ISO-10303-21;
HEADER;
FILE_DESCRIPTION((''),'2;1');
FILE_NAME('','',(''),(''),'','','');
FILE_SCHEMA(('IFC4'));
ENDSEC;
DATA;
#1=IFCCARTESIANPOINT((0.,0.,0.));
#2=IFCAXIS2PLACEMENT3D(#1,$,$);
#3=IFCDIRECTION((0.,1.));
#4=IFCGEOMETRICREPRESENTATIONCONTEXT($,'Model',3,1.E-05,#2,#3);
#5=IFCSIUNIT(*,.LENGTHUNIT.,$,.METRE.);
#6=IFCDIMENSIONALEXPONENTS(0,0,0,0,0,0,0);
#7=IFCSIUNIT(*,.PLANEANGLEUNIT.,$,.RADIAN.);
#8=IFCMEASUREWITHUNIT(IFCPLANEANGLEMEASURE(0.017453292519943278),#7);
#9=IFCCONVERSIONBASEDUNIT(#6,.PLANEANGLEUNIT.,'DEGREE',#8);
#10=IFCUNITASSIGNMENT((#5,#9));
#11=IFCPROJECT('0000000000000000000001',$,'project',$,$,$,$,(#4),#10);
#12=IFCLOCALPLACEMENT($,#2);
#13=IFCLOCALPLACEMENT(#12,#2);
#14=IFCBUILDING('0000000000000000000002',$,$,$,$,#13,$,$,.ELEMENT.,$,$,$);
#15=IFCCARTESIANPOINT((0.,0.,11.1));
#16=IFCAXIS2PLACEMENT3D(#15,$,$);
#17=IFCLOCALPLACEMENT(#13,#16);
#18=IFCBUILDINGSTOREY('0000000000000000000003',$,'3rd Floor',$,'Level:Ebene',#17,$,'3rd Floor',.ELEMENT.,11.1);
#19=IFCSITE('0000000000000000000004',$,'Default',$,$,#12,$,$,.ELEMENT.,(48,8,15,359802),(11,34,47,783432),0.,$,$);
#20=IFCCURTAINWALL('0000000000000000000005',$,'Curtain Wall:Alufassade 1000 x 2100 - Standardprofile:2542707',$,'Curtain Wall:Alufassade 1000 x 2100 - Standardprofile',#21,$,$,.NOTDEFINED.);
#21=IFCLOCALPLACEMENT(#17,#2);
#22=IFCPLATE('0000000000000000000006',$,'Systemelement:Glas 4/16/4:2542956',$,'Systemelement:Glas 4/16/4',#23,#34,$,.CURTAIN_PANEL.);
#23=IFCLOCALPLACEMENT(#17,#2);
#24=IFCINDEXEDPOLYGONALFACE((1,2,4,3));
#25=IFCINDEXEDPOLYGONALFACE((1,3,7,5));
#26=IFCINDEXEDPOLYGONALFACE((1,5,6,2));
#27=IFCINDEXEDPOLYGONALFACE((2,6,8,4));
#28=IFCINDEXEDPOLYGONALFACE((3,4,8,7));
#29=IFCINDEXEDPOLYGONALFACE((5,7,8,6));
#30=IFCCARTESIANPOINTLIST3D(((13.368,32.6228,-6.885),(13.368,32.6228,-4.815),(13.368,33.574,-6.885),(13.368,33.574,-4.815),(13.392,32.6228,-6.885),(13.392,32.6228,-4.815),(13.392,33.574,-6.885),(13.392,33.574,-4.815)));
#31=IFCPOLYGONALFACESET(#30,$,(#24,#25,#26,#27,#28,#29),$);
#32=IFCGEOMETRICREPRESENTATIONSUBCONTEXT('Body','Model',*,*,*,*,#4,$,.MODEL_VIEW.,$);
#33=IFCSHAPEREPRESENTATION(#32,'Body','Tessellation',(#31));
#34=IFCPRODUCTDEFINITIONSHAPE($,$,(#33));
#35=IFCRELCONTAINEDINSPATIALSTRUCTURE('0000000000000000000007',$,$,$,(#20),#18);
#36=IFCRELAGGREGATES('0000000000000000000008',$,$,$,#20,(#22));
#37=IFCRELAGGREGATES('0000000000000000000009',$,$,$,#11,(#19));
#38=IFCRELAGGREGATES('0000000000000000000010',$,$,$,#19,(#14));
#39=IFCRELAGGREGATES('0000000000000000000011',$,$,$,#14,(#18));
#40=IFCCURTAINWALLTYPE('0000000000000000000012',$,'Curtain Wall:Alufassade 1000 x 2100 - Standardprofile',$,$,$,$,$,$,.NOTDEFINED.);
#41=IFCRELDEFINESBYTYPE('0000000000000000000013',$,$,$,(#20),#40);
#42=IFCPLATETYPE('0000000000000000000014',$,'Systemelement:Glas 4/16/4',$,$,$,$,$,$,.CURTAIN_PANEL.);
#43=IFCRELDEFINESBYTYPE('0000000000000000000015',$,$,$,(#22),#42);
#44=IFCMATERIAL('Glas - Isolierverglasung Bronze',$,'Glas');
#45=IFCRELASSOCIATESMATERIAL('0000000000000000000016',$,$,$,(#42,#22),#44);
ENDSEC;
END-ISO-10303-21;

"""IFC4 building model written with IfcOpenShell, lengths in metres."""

from ifc_helpers import new_model, entity, si_unit, converted_unit, direction, frame, origin, place, context, subcontext, project, spatial, indexed_curve, outline, extrude, source, transform, mapped, material, type_object, type_shapes, element, aggregate, save


model = new_model("IFC4")

# Units and contexts
model_context = context("Model", 3, precision=1e-05, world=origin(), true_north=direction((0.0, 1.0)))
body_context = subcontext(model_context, "Body", "Model", "MODEL_VIEW")
ifc_project = project(units=[si_unit("LENGTHUNIT", "METRE"), converted_unit("PLANEANGLEUNIT", "DEGREE", entity("IfcPlaneAngleMeasure", 0.017453292519943278), si_unit("PLANEANGLEUNIT", "RADIAN"), dimensions=[0, 0, 0, 0, 0, 0, 0])], contexts=[model_context])

# Site, building, storey
site_placement = place(None, origin())
site = spatial("IfcSite", under=ifc_project, at=site_placement, Name="Default", CompositionType="ELEMENT", RefLatitude=(48, 8, 15, 359802), RefLongitude=(11, 34, 47, 783432), RefElevation=0.0)
building_placement = place(site_placement, origin())
building = spatial("IfcBuilding", under=site, at=building_placement, CompositionType="ELEMENT")
storey_placement = place(building_placement, frame((0.0, 0.0, 11.1)))
storey = spatial("IfcBuildingStorey", under=building, at=storey_placement, Name="3rd Floor", ObjectType="Level:Ebene", LongName="3rd Floor", CompositionType="ELEMENT", Elevation=11.1)

# Curtain wall, plate
curtain_wall_type = type_object("IfcCurtainWallType", Name="Curtain Wall:Alufassade 1000 x 2100 - Standardprofile", PredefinedType="NOTDEFINED")
curtain_wall_placement = place(storey_placement, frame((0.0, 0.0, -11.1)))
curtain_wall = element("IfcCurtainWall", 1, at=curtain_wall_placement, inside=storey, type_object=curtain_wall_type, Name="Curtain Wall:Alufassade 1000 x 2100 - Standardprofile:2542707", ObjectType="Curtain Wall:Alufassade 1000 x 2100 - Standardprofile", PredefinedType="NOTDEFINED")
ifc_material_1 = material(Name="Glas - Isolierverglasung Bronze", Category="Glas")
plate_type_1 = type_object("IfcPlateType", Name="Systemelement:Glas 4/16/4", PredefinedType="CURTAIN_PANEL", material=ifc_material_1)
shared_shape_1 = source(origin(), body_context, "Body", "SweptSolid", [
    extrude(outline(indexed_curve([(-0.012, -0.4756), (0.012, -0.4756), (0.012, 0.4756), (-0.012, 0.4756), (-0.012, -0.4756)], self_intersect=False)), frame((0.0, 0.0, 0.0), z_axis=(0.0, 0.0, 1.0), x_axis=(0.0, 1.0, 0.0)), (0.0, 0.0, 1.0), 2.07),
])
type_shapes(plate_type_1, [shared_shape_1])
plate_1_placement = place(curtain_wall_placement, frame((13.38, 33.0984, 4.215), z_axis=(0.0, 0.0, 1.0), x_axis=(0.0, -1.0, 0.0)))
plate_1 = element("IfcPlate", 2, at=plate_1_placement, type_object=plate_type_1, material=ifc_material_1, Name="Systemelement:Glas 4/16/4:2542956", ObjectType="Systemelement:Glas 4/16/4", PredefinedType="CURTAIN_PANEL", context=body_context, shape_type="MappedRepresentation", body=[
    mapped(shared_shape_1, transform((0.0, 0.0, 0.0), scale=1.0)),
])
aggregate(curtain_wall, [plate_1])

save(model, "model.ifc")
